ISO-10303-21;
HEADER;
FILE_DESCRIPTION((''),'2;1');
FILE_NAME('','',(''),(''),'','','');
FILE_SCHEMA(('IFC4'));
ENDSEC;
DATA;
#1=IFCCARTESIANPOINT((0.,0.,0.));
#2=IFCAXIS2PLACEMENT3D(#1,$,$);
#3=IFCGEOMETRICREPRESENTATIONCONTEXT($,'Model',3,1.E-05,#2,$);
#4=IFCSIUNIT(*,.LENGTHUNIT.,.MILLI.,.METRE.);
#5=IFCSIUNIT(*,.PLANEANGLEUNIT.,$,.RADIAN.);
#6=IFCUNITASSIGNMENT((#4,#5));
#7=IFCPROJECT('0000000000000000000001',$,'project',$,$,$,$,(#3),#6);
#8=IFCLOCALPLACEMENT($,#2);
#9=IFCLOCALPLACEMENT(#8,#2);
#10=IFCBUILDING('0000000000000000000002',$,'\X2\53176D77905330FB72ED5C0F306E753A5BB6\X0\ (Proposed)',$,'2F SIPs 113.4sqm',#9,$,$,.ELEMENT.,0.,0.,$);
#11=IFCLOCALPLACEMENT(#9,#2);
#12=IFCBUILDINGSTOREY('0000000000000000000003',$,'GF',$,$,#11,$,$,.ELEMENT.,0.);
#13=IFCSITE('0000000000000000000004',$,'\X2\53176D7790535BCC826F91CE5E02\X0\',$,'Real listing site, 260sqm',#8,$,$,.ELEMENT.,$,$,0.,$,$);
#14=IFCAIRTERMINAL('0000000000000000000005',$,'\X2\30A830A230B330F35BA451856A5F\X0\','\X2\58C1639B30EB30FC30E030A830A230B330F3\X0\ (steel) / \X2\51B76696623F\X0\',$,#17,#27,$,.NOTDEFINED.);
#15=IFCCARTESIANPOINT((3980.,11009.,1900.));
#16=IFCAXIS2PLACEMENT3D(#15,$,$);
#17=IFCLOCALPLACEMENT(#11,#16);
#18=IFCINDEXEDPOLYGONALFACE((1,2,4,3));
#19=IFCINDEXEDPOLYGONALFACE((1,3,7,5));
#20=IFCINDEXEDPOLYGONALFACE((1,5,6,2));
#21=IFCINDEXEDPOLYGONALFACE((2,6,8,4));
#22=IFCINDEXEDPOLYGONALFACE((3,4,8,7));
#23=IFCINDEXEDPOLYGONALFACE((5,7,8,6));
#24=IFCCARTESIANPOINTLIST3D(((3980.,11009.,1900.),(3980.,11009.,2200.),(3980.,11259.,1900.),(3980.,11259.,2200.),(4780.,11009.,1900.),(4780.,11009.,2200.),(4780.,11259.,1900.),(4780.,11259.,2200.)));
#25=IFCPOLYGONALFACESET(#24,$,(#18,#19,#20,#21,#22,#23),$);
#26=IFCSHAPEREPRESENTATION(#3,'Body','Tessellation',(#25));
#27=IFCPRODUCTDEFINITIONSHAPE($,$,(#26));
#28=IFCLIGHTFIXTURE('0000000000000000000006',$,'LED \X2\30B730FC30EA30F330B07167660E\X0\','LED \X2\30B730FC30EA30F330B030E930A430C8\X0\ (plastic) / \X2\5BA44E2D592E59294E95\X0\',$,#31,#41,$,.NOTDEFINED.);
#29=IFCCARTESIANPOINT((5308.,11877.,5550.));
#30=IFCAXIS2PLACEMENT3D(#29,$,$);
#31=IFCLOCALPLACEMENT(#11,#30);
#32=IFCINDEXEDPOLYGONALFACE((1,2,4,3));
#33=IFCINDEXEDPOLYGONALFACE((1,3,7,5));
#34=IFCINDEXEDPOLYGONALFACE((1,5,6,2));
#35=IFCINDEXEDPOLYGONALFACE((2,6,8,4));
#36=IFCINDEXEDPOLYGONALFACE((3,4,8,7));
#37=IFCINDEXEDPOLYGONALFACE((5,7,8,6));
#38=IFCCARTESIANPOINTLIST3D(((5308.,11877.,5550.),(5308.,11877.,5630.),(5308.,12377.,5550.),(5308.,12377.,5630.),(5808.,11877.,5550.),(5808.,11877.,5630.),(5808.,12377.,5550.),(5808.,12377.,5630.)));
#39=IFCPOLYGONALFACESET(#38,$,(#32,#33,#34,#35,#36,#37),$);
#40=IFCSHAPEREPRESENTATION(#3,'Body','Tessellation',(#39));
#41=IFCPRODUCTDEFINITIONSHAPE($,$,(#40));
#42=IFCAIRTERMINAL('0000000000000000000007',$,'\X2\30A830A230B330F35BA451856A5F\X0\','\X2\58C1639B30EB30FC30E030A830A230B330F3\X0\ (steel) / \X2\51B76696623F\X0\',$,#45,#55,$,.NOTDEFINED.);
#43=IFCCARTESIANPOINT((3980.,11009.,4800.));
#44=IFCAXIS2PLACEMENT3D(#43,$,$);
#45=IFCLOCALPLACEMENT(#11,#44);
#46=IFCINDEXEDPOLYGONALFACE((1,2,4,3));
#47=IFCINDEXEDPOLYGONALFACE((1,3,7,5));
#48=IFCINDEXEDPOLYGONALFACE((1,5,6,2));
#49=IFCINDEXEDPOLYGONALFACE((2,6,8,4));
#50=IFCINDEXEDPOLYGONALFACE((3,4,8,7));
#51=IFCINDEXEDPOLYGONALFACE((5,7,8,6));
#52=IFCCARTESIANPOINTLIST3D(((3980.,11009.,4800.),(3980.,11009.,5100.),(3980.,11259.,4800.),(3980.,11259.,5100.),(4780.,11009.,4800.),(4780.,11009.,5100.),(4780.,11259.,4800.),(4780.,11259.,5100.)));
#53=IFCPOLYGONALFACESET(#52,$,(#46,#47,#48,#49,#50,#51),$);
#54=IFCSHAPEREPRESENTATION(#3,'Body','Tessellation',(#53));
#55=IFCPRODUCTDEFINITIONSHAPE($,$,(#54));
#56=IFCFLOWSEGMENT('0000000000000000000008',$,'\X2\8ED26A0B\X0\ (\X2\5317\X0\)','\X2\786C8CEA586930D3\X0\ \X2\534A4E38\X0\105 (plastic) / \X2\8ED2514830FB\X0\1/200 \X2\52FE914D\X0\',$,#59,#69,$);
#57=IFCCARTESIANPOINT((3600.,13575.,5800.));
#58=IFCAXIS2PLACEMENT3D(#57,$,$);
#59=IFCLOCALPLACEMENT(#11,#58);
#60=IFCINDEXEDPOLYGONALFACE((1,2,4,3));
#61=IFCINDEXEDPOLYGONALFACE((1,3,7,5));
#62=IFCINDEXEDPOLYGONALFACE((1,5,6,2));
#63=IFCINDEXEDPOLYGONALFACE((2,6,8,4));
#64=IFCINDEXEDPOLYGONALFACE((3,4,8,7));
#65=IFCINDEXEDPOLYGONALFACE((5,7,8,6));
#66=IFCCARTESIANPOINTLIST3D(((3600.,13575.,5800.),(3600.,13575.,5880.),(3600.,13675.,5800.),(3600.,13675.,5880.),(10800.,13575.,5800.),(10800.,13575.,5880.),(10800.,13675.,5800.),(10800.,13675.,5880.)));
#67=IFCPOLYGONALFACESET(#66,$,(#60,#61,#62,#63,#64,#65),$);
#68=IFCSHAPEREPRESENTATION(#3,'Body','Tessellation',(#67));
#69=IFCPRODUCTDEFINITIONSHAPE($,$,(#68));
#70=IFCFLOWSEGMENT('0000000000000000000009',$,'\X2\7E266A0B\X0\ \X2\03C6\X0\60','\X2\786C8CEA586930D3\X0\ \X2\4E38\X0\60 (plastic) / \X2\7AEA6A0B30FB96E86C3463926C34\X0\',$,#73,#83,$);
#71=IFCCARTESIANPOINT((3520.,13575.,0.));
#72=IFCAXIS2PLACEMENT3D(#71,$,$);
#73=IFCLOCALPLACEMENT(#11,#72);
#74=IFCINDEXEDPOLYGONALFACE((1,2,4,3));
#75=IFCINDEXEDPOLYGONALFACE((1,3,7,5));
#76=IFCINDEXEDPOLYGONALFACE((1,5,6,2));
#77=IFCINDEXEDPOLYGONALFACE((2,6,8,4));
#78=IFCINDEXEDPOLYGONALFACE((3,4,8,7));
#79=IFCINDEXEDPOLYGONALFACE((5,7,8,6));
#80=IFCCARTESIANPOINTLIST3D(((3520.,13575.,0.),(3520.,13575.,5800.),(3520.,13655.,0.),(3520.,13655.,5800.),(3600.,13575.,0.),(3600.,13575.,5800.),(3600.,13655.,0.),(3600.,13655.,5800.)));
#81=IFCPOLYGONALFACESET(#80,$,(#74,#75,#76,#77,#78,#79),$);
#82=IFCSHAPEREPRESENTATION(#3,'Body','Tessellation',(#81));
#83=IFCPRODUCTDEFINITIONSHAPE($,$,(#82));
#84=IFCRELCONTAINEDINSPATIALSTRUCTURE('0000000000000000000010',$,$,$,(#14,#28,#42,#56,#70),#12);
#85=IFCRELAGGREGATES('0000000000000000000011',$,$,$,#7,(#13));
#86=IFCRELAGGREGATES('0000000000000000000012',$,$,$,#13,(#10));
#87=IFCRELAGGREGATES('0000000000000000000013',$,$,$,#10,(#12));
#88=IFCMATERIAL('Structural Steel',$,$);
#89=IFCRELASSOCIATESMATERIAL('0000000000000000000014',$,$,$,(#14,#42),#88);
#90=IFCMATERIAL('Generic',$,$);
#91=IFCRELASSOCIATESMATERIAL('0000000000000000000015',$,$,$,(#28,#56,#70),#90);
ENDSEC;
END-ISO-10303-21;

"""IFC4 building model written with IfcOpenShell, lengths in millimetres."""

from ifc_helpers import new_model, si_unit, frame, frame_2d, origin, place, context, project, spatial, rectangle, extrude, material, element, save


model = new_model("IFC4")

# Units and contexts
model_context = context("Model", 3, precision=1e-05, world=origin())
ifc_project = project(units=[si_unit("LENGTHUNIT", "METRE", prefix="MILLI"), si_unit("PLANEANGLEUNIT", "RADIAN")], contexts=[model_context])

# Site, building, storey
site_placement = place(None, origin())
site = spatial("IfcSite", under=ifc_project, at=site_placement, Name="北海道富良野市", ObjectType="Real listing site, 260sqm", CompositionType="ELEMENT", RefElevation=0.0)
building_placement = place(site_placement, origin())
building = spatial("IfcBuilding", under=site, at=building_placement, Name="北海道・狭小の町家 (Proposed)", ObjectType="2F SIPs 113.4sqm", CompositionType="ELEMENT", ElevationOfRefHeight=0.0, ElevationOfTerrain=0.0)
storey_placement = place(building_placement, origin())
storey = spatial("IfcBuildingStorey", under=building, at=storey_placement, Name="GF", CompositionType="ELEMENT", Elevation=0.0)

# Shared definitions
ifc_material_1 = material(Name="Generic")

# Shared definitions
ifc_material_2 = material(Name="Structural Steel")

# Air terminal
air_terminal_1_placement = place(storey_placement, frame((3980.0, 11009.0, 1900.0)))
element("IfcAirTerminal", 1, at=air_terminal_1_placement, inside=storey, material=ifc_material_2, Name="エアコン室内機", Description="壁掛ルームエアコン (steel) / 冷暖房", PredefinedType="NOTDEFINED", context=model_context, shape_type="SweptSolid", body=[
    extrude(rectangle(XDim=800.0, YDim=250.0, at=frame_2d((400.0, 125.0))), frame((3980.0, 11009.0, 1900.0)), (0.0, 0.0, 1.0), 300.0),
])

# Light fixture
light_fixture_placement = place(storey_placement, frame((5308.0, 11877.0, 5550.0)))
element("IfcLightFixture", 2, at=light_fixture_placement, inside=storey, material=ifc_material_1, Name="LED シーリング照明", Description="LED シーリングライト (plastic) / 室中央天井", PredefinedType="NOTDEFINED", context=model_context, shape_type="SweptSolid", body=[
    extrude(rectangle(XDim=500.0, YDim=500.0, at=frame_2d((250.0, 250.0))), frame((5308.0, 11877.0, 5550.0)), (0.0, 0.0, 1.0), 80.0),
])

# Air terminal
air_terminal_2_placement = place(storey_placement, frame((3980.0, 11009.0, 4800.0)))
element("IfcAirTerminal", 3, at=air_terminal_2_placement, inside=storey, material=ifc_material_2, Name="エアコン室内機", Description="壁掛ルームエアコン (steel) / 冷暖房", PredefinedType="NOTDEFINED", context=model_context, shape_type="SweptSolid", body=[
    extrude(rectangle(XDim=800.0, YDim=250.0, at=frame_2d((400.0, 125.0))), frame((3980.0, 11009.0, 4800.0)), (0.0, 0.0, 1.0), 300.0),
])

# Flow segments
flow_segment_1_placement = place(storey_placement, frame((3600.0, 13575.0, 5800.0)))
element("IfcFlowSegment", 4, at=flow_segment_1_placement, inside=storey, material=ifc_material_1, Name="軒樋 (北)", Description="硬質塩ビ 半丸105 (plastic) / 軒先・1/200 勾配", context=model_context, shape_type="SweptSolid", body=[
    extrude(rectangle(XDim=7200.0, YDim=100.0, at=frame_2d((3600.0, 50.0))), frame((3600.0, 13575.0, 5800.0)), (0.0, 0.0, 1.0), 80.0),
])
flow_segment_2_placement = place(storey_placement, frame((3520.0, 13575.0, 0.0)))
element("IfcFlowSegment", 5, at=flow_segment_2_placement, inside=storey, material=ifc_material_1, Name="縦樋 φ60", Description="硬質塩ビ 丸60 (plastic) / 竪樋・雨水排水", context=model_context, shape_type="SweptSolid", body=[
    extrude(rectangle(XDim=80.0, YDim=80.0, at=frame_2d((40.0, 40.0))), frame((3520.0, 13575.0, 0.0)), (0.0, 0.0, 1.0), 5800.0),
])

save(model, "model.ifc")
